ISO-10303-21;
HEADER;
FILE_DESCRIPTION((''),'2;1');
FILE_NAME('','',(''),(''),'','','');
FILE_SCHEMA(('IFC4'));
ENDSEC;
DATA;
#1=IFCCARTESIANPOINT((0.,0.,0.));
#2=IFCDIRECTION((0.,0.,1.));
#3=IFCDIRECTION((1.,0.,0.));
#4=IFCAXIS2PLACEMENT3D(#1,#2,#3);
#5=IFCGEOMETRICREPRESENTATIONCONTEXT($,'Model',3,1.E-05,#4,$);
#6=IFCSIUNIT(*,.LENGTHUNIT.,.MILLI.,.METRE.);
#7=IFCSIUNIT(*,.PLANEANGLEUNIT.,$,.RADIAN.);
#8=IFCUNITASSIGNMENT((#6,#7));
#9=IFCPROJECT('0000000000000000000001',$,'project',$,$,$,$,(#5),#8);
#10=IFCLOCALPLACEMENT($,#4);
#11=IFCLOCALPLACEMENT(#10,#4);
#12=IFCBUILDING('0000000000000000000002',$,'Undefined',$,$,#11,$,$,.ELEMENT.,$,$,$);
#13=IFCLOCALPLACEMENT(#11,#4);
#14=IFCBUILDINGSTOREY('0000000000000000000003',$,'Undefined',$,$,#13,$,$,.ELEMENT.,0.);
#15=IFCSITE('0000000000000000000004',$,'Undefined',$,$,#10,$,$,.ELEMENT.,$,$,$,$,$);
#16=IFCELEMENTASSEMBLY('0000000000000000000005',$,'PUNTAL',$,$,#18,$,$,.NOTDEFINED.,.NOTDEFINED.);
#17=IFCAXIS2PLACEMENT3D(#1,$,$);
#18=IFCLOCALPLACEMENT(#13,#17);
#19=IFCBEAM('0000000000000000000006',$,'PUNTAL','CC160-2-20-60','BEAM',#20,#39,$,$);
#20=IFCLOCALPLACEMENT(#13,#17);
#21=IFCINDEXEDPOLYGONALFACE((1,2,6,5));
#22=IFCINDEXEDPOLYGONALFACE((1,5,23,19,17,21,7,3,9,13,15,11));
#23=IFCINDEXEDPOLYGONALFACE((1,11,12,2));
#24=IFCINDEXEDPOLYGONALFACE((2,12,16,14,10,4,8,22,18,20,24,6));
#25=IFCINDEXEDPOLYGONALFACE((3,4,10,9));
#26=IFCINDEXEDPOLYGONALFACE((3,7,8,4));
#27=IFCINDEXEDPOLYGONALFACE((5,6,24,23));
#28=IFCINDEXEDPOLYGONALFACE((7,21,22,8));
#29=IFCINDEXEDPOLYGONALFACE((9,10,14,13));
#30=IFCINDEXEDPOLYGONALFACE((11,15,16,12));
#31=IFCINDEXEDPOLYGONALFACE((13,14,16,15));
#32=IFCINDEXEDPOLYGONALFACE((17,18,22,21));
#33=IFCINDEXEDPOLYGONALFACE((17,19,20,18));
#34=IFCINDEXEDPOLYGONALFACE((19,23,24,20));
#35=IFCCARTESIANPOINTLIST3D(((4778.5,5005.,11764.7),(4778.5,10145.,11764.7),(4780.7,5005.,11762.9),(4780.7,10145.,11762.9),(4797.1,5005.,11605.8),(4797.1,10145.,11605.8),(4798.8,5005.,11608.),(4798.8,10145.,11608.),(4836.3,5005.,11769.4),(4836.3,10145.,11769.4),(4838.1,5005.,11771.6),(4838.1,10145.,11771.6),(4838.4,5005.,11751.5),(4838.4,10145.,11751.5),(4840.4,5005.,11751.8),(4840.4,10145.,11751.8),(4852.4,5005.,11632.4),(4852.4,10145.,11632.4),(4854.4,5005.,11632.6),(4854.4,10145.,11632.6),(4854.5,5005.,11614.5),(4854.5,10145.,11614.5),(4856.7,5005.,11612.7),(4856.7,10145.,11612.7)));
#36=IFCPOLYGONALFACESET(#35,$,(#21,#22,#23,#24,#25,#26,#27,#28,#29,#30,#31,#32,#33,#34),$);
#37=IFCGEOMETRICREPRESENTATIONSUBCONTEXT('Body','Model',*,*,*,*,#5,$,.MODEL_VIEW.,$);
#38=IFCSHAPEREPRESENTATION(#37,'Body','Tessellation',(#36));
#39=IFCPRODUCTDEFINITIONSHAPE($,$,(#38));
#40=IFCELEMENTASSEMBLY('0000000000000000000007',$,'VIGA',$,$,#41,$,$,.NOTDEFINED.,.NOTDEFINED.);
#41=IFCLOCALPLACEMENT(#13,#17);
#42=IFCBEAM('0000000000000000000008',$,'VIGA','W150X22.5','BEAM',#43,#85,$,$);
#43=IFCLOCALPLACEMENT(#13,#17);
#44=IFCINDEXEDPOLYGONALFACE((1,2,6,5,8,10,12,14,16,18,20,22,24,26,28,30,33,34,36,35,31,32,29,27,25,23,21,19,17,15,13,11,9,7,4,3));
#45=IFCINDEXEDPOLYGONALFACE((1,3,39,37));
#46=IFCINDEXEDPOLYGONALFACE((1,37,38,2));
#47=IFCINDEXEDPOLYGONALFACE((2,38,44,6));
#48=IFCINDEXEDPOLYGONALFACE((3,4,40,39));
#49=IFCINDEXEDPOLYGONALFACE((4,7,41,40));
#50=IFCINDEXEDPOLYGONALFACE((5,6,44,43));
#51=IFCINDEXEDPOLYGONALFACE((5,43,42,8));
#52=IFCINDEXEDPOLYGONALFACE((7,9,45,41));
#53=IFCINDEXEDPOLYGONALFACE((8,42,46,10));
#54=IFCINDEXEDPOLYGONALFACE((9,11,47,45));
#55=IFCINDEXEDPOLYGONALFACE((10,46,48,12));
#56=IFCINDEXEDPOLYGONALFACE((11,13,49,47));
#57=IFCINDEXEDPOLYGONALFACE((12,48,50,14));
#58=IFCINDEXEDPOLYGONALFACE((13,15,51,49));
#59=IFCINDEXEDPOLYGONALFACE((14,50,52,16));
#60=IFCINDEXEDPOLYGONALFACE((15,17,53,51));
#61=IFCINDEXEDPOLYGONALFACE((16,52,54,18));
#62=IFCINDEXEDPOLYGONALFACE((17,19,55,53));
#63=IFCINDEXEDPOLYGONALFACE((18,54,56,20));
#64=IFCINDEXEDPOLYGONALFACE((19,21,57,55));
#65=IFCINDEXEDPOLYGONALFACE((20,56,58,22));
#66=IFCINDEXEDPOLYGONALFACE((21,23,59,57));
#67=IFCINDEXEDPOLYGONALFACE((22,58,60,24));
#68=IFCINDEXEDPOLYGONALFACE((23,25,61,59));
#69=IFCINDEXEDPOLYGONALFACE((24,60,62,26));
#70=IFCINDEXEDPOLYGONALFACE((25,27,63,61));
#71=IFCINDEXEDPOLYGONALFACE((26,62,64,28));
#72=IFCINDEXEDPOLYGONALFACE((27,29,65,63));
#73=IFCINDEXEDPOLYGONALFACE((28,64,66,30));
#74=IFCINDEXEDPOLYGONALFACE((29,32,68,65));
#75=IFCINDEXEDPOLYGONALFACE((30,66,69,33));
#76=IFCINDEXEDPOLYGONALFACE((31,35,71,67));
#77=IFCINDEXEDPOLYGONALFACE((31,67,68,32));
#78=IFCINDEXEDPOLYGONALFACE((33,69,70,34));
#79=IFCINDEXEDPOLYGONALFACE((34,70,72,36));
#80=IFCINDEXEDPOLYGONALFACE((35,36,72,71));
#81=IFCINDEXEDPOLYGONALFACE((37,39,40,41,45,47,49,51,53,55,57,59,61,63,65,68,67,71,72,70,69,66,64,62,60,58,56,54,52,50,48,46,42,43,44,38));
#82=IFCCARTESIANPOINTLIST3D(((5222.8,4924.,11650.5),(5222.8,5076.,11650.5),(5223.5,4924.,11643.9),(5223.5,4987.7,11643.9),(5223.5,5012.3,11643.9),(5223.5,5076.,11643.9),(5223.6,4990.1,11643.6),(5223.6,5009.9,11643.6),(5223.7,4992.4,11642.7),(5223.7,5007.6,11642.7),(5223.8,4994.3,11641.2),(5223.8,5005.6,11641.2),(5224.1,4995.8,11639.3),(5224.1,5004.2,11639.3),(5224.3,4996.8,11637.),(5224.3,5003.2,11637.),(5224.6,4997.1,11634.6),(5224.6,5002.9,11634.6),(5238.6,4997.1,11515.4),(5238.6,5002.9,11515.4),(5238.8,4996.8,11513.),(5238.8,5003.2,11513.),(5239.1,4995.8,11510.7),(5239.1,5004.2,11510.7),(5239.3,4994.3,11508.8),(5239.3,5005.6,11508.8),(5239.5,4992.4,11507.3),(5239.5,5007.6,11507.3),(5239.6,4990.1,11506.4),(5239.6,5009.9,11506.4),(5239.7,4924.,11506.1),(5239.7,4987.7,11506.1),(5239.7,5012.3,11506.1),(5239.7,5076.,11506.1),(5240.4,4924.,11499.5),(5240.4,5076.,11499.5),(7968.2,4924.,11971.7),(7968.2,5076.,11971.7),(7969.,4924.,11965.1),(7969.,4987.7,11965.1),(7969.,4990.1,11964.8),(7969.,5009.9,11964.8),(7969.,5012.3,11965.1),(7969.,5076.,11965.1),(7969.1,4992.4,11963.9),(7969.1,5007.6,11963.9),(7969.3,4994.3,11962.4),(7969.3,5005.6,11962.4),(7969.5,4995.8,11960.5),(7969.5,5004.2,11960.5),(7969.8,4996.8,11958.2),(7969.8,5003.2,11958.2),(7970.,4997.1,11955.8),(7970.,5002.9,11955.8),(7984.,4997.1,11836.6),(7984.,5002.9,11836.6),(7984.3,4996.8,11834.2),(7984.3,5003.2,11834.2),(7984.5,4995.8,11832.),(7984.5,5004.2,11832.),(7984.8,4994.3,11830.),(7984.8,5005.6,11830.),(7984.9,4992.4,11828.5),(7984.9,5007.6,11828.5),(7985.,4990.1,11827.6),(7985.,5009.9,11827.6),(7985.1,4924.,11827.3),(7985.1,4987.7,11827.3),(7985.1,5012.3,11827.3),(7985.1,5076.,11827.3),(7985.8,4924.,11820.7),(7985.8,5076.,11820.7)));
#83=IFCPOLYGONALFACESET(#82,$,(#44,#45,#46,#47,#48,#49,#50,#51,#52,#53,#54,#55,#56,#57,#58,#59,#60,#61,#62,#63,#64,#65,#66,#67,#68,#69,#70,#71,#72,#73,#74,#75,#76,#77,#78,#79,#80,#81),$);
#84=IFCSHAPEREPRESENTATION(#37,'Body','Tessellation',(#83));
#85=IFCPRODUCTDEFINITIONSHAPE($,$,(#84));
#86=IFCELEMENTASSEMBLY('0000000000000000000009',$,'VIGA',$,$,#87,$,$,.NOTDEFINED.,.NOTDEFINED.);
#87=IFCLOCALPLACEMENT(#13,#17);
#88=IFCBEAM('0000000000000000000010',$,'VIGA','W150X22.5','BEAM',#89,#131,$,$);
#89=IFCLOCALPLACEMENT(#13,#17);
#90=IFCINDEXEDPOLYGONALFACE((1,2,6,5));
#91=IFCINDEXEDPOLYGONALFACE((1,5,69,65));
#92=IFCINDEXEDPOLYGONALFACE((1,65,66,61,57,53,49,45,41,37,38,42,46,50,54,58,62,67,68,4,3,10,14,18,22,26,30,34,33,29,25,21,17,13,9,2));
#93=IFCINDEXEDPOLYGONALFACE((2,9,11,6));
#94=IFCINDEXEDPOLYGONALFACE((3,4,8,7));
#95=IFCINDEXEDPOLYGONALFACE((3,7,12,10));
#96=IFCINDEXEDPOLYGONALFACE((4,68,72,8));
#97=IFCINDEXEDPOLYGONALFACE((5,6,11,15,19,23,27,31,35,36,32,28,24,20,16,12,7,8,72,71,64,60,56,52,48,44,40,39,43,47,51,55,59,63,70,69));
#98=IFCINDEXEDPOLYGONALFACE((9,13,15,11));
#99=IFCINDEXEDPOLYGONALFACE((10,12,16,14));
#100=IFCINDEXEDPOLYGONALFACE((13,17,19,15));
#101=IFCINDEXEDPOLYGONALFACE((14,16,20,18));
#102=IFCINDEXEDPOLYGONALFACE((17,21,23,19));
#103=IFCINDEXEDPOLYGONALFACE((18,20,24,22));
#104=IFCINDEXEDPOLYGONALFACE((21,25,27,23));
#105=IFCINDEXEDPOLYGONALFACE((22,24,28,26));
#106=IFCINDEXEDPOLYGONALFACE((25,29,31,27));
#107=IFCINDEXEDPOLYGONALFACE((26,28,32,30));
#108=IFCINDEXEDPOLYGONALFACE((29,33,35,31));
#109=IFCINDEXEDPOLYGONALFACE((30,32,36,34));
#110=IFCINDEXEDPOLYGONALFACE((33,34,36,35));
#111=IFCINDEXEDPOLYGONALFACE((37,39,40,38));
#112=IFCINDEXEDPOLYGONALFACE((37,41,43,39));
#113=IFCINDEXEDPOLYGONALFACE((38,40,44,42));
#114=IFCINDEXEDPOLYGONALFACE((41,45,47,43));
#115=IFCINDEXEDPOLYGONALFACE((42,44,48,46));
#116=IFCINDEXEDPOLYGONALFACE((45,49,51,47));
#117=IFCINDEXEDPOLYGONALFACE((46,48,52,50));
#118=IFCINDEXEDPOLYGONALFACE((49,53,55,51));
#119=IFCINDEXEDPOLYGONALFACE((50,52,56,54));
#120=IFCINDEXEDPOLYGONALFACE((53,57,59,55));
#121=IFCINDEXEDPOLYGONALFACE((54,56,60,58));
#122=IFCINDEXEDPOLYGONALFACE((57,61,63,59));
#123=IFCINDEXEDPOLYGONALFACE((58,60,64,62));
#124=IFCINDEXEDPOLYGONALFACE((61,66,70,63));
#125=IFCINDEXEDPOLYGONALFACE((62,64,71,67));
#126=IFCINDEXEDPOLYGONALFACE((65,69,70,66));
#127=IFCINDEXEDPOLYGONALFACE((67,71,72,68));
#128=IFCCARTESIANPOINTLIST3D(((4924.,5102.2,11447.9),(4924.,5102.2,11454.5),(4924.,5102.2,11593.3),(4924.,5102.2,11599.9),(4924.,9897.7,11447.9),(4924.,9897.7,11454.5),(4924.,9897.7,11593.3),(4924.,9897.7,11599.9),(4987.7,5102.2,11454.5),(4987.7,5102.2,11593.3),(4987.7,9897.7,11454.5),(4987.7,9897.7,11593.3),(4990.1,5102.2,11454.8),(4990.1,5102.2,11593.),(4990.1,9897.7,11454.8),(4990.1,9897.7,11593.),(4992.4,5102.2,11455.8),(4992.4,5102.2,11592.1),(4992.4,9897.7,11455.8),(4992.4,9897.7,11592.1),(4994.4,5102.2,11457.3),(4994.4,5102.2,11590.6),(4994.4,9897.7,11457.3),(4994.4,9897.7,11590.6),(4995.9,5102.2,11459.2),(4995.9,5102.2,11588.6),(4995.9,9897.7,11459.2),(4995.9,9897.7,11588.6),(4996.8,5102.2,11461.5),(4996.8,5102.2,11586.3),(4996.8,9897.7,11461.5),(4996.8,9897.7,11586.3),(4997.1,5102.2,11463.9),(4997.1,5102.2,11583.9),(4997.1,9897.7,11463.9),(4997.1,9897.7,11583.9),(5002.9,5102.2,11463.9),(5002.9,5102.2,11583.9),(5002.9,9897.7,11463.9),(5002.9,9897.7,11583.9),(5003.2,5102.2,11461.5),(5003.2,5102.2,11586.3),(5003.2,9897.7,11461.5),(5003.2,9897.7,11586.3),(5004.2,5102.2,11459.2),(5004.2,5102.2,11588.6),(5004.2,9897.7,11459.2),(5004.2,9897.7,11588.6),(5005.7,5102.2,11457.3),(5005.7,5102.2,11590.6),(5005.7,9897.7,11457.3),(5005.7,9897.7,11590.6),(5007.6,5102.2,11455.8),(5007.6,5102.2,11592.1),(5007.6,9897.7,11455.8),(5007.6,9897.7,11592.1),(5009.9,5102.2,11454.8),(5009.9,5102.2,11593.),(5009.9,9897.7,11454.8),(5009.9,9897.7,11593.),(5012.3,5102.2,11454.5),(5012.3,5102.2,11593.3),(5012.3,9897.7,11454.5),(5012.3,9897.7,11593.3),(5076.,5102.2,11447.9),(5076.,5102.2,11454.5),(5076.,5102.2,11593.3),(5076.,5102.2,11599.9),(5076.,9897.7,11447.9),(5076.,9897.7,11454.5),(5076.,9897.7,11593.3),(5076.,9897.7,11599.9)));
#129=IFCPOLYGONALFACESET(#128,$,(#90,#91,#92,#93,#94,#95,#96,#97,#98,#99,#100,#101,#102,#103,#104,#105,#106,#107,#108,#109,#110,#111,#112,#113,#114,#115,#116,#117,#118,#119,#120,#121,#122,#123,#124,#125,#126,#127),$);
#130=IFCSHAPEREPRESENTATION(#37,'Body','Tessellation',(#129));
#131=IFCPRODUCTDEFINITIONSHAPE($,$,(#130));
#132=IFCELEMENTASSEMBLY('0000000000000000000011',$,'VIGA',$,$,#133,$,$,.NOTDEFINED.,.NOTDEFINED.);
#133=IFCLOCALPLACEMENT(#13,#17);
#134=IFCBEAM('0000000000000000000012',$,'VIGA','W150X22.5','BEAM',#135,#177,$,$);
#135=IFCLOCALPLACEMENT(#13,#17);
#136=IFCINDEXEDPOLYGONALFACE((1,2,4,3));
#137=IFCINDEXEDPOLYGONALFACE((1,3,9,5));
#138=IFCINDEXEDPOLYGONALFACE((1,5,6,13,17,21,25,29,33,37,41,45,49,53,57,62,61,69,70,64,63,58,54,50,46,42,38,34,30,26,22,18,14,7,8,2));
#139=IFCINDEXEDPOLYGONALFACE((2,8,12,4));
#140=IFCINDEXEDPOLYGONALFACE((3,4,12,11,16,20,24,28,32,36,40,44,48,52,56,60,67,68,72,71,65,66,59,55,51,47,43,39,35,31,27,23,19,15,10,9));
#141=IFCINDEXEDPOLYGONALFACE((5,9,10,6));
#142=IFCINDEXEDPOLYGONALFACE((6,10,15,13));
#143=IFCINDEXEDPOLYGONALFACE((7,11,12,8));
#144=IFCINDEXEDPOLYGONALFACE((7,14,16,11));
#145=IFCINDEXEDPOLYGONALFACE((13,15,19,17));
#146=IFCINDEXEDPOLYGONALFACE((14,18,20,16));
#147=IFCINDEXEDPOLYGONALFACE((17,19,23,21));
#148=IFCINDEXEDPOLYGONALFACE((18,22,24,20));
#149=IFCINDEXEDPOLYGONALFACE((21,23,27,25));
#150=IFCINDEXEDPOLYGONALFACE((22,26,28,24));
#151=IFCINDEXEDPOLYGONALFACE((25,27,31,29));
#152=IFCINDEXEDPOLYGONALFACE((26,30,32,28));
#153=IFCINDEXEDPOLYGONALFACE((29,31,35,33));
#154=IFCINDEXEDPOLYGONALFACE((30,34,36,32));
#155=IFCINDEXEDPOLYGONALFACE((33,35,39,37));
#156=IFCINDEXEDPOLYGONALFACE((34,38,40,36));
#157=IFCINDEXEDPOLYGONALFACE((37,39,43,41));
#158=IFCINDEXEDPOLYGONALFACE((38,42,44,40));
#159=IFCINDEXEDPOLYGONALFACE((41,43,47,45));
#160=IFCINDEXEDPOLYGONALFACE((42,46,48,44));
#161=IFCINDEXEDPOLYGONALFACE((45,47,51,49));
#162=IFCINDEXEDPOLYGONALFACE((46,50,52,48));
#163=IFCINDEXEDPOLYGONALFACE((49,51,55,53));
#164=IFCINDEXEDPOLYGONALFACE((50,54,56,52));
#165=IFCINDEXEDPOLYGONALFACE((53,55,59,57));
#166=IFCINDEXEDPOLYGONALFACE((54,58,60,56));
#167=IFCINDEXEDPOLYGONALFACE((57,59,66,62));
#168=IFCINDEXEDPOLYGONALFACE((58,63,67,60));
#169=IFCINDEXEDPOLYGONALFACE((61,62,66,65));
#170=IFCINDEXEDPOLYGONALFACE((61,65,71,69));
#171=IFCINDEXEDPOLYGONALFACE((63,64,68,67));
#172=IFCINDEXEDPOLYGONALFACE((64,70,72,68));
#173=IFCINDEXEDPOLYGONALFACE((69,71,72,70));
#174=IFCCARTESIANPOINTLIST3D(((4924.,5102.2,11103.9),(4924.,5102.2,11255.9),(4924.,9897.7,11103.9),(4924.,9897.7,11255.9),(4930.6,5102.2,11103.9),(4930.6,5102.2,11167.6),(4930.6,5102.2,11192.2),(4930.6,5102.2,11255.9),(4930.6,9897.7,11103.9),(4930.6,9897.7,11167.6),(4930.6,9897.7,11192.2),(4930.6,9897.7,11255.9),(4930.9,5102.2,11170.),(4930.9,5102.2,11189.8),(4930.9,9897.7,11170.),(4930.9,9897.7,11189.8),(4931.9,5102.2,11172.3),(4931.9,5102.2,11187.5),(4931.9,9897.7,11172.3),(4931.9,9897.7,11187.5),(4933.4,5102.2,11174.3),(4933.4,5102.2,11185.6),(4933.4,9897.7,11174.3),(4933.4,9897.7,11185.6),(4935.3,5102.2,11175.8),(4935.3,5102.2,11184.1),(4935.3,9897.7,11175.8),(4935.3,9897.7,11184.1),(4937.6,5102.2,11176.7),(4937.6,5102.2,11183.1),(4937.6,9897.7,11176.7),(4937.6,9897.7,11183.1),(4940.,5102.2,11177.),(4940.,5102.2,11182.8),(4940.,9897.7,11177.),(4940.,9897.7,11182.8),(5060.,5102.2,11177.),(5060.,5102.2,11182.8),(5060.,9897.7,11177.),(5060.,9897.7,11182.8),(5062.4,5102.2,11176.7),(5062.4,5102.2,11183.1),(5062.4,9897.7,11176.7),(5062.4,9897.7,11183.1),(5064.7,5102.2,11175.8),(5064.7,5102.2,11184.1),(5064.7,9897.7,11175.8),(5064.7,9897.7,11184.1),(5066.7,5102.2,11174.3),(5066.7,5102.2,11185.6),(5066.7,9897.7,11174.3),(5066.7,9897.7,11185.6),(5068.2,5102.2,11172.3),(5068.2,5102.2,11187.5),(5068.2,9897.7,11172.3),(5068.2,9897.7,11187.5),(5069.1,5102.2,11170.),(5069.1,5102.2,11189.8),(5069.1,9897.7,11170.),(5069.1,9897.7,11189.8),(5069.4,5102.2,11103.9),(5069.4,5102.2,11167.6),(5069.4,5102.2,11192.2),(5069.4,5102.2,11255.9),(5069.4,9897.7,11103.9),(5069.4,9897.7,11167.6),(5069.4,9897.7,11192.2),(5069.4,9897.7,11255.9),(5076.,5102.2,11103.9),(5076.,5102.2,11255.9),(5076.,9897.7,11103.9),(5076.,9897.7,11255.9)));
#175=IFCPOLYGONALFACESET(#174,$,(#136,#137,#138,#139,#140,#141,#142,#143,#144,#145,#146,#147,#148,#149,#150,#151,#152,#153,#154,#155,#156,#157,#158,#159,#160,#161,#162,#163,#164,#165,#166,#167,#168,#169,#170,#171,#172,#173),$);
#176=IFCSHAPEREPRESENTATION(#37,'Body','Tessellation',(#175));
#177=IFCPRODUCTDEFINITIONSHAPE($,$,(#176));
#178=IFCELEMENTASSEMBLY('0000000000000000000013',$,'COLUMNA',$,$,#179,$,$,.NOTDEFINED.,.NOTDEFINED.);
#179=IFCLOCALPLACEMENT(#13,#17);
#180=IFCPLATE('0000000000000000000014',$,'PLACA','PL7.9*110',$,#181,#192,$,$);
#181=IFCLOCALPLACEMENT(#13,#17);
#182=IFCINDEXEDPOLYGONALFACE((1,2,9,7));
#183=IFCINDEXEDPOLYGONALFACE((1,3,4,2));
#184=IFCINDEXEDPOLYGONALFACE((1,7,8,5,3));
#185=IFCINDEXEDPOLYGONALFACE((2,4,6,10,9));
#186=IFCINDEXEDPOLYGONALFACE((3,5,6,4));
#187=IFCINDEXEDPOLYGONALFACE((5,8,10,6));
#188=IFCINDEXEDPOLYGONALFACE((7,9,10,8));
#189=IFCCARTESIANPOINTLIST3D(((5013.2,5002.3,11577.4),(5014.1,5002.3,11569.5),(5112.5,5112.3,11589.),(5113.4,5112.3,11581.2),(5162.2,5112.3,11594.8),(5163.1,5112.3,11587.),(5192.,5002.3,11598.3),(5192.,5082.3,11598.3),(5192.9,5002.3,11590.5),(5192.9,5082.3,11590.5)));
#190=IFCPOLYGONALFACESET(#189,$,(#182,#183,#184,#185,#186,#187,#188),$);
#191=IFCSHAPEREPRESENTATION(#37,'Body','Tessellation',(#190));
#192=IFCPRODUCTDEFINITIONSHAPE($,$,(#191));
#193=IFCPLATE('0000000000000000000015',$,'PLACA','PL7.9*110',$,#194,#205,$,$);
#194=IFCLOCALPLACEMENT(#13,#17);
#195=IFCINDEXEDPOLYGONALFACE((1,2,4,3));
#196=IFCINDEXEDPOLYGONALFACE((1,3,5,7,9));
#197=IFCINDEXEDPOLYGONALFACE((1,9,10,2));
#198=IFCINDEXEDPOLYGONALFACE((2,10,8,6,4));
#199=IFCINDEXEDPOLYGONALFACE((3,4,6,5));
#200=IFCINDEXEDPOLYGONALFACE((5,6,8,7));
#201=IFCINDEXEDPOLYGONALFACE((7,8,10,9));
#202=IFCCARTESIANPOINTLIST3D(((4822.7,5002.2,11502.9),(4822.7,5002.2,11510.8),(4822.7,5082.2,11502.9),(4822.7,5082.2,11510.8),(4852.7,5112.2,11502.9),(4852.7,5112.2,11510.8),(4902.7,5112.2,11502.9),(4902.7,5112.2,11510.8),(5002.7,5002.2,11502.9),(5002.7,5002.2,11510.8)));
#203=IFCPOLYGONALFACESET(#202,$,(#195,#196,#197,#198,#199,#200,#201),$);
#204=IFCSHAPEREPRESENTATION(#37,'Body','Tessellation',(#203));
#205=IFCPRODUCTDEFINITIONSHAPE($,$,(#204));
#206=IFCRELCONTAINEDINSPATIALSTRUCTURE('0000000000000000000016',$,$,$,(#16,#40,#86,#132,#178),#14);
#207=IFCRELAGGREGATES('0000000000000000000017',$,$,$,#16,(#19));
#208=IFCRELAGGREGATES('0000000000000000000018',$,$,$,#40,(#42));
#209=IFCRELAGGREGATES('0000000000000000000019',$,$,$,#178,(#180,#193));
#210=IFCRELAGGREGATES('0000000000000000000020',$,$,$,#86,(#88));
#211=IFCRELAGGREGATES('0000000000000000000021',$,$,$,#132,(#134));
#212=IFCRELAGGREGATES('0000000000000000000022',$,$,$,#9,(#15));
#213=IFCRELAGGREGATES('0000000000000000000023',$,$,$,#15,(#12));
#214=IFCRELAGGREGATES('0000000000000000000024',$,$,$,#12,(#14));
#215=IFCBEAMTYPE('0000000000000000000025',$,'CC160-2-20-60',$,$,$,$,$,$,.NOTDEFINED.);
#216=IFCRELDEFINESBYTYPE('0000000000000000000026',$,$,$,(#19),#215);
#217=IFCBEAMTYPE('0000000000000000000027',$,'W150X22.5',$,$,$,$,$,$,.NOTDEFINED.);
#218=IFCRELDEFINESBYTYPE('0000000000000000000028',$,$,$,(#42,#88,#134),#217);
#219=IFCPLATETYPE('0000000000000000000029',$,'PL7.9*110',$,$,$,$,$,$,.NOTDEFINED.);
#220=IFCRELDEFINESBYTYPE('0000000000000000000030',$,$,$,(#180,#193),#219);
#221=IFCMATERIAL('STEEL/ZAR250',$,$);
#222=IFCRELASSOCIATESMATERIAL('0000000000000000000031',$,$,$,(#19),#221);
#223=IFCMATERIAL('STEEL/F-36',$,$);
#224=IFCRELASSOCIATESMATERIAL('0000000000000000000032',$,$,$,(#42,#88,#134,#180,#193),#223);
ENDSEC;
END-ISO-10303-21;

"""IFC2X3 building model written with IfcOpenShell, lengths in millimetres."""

from ifc_helpers import new_model, si_unit, frame, origin_with_axes, origin_2d_with_axis, place, context, subcontext, project, spatial, polyline, i_section, c_section, outline, extrude, material, type_object, element, aggregate, save


model = new_model("IFC2X3")

# Units and contexts
model_context = context("Model", 3, precision=1e-05, world=origin_with_axes())
body_context = subcontext(model_context, "Body", "Model", "MODEL_VIEW")
ifc_project = project(units=[si_unit("LENGTHUNIT", "METRE", prefix="MILLI"), si_unit("PLANEANGLEUNIT", "RADIAN")], contexts=[model_context])

# Site, building, storey
site_placement = place(None, origin_with_axes())
site = spatial("IfcSite", under=ifc_project, at=site_placement, Name="Undefined", CompositionType="ELEMENT")
building_placement = place(site_placement, origin_with_axes())
building = spatial("IfcBuilding", under=site, at=building_placement, Name="Undefined", CompositionType="ELEMENT")
storey_placement = place(building_placement, origin_with_axes())
storey = spatial("IfcBuildingStorey", under=building, at=storey_placement, Name="Undefined", CompositionType="ELEMENT", Elevation=0.0)

# Element assemblies, beams
assembly_1_placement = place(storey_placement, origin_with_axes())
assembly_1 = element("IfcElementAssembly", 1, at=assembly_1_placement, inside=storey, Name="PUNTAL", AssemblyPlace="NOTDEFINED", PredefinedType="NOTDEFINED")
ifc_material_1 = material(Name="STEEL/ZAR250")
beam_type_1 = type_object("IfcBeamType", Name="CC160-2-20-60", PredefinedType="NOTDEFINED")
beam_1_placement = place(assembly_1_placement, frame((4817.6, 5005.0, 11688.7), z_axis=(-0.116208, 0.0, 0.993225), x_axis=(0.0, 1.0, 0.0)))
beam_1 = element("IfcBeam", 2, at=beam_1_placement, type_object=beam_type_1, material=ifc_material_1, Name="PUNTAL", Description="CC160-2-20-60", ObjectType="BEAM", context=body_context, shape_type="SweptSolid", body=[
    extrude(c_section(Depth=160.0, Width=60.0, WallThickness=2.0, Girth=20.0, at=origin_2d_with_axis()), frame((5140.0, 0.0, 0.0), z_axis=(-1.0, 0.0, 0.0), x_axis=(0.0, -1.0, 0.0)), (0.0, 0.0, 1.0), 5140.0),
])
aggregate(assembly_1, [beam_1])
assembly_2_placement = place(storey_placement, origin_with_axes())
assembly_2 = element("IfcElementAssembly", 3, at=assembly_2_placement, inside=storey, Name="VIGA", AssemblyPlace="NOTDEFINED", PredefinedType="NOTDEFINED")
ifc_material_2 = material(Name="STEEL/F-36")
beam_type_2 = type_object("IfcBeamType", Name="W150X22.5", PredefinedType="NOTDEFINED")
beam_2_placement = place(assembly_2_placement, frame((5231.6, 5000.0, 11575.0), z_axis=(0.116208, 0.0, -0.993225), x_axis=(0.993225, 0.0, 0.116208)))
beam_2 = element("IfcBeam", 4, at=beam_2_placement, type_object=beam_type_2, material=ifc_material_2, Name="VIGA", Description="W150X22.5", ObjectType="BEAM", context=body_context, shape_type="SweptSolid", body=[
    extrude(i_section(OverallWidth=152.0, OverallDepth=152.0, WebThickness=5.8, FlangeThickness=6.6, FilletRadius=9.4, at=origin_2d_with_axis()), frame((2764.1, 0.0, 0.0), z_axis=(-1.0, 0.0, 0.0), x_axis=(0.0, -1.0, 0.0)), (0.0, 0.0, 1.0), 2764.2),
])
aggregate(assembly_2, [beam_2])
assembly_3_placement = place(storey_placement, origin_with_axes())
assembly_3 = element("IfcElementAssembly", 5, at=assembly_3_placement, inside=storey, Name="VIGA", AssemblyPlace="NOTDEFINED", PredefinedType="NOTDEFINED")
beam_3_placement = place(assembly_3_placement, frame((5000.0, 5102.3, 11523.9), z_axis=(0.0, 0.0, 1.0), x_axis=(0.0, 1.0, 0.0)))
beam_3 = element("IfcBeam", 6, at=beam_3_placement, type_object=beam_type_2, material=ifc_material_2, Name="VIGA", Description="W150X22.5", ObjectType="BEAM", context=body_context, shape_type="SweptSolid", body=[
    extrude(i_section(OverallWidth=152.0, OverallDepth=152.0, WebThickness=5.8, FlangeThickness=6.6, FilletRadius=9.4, at=origin_2d_with_axis()), frame((4795.5, 0.0, 0.0), z_axis=(-1.0, 0.0, 0.0), x_axis=(0.0, -1.0, 0.0)), (0.0, 0.0, 1.0), 4795.5),
])
assembly_4_placement = place(storey_placement, origin_with_axes())
assembly_4 = element("IfcElementAssembly", 7, at=assembly_4_placement, inside=storey, Name="VIGA", AssemblyPlace="NOTDEFINED", PredefinedType="NOTDEFINED")
beam_4_placement = place(assembly_4_placement, frame((5000.0, 5102.3, 11179.9), z_axis=(-1.0, 0.0, 0.0), x_axis=(0.0, 1.0, 0.0)))
beam_4 = element("IfcBeam", 8, at=beam_4_placement, type_object=beam_type_2, material=ifc_material_2, Name="VIGA", Description="W150X22.5", ObjectType="BEAM", context=body_context, shape_type="SweptSolid", body=[
    extrude(i_section(OverallWidth=152.0, OverallDepth=152.0, WebThickness=5.8, FlangeThickness=6.6, FilletRadius=9.4, at=origin_2d_with_axis()), frame((4795.5, 0.0, 0.0), z_axis=(-1.0, 0.0, 0.0), x_axis=(0.0, -1.0, 0.0)), (0.0, 0.0, 1.0), 4795.5),
])

# Element assembly, plates
assembly_5_placement = place(storey_placement, origin_with_axes())
assembly_5 = element("IfcElementAssembly", 9, at=assembly_5_placement, inside=storey, Name="COLUMNA", AssemblyPlace="NOTDEFINED", PredefinedType="NOTDEFINED")
plate_type_1 = type_object("IfcPlateType", Name="PL7.9*110", PredefinedType="NOTDEFINED")
plate_1_placement = place(assembly_5_placement, frame((5113.0, 5112.3, 11585.1), z_axis=(-0.116208, 0.00013, 0.993225), x_axis=(-0.668127, -0.73994, -0.078075)))
plate_1 = element("IfcPlate", 10, at=plate_1_placement, type_object=plate_type_1, material=ifc_material_2, Name="PLACA", Description="PL7.9*110", context=body_context, shape_type="SweptSolid", body=[
    extrude(outline(polyline([(0.0, 0.0), (148.7, 0.0), (27.6, 133.2), (-31.6, 79.4), (-33.6, 37.0), (0.0, 0.0)])), frame((0.0, 0.0, -4.0), z_axis=(0.0, 0.0, 1.0), x_axis=(1.0, 0.0, 0.0)), (0.0, 0.0, 1.0), 7.9),
])
plate_2_placement = place(assembly_5_placement, frame((4822.7, 5082.2, 11506.8), z_axis=(0.0, 0.0, 1.0), x_axis=(0.0, -1.0, 0.0)))
plate_2 = element("IfcPlate", 11, at=plate_2_placement, type_object=plate_type_1, material=ifc_material_2, Name="PLACA", Description="PL7.9*110", context=body_context, shape_type="SweptSolid", body=[
    extrude(outline(polyline([(0.0, 0.0), (80.0, 0.0), (80.0, 180.0), (-30.0, 80.0), (-30.0, 30.0), (0.0, 0.0)])), frame((0.0, 0.0, -4.0), z_axis=(0.0, 0.0, 1.0), x_axis=(1.0, 0.0, 0.0)), (0.0, 0.0, 1.0), 7.9),
])

aggregate(assembly_5, [plate_1, plate_2])

aggregate(assembly_3, [beam_3])
aggregate(assembly_4, [beam_4])

save(model, "model.ifc")
